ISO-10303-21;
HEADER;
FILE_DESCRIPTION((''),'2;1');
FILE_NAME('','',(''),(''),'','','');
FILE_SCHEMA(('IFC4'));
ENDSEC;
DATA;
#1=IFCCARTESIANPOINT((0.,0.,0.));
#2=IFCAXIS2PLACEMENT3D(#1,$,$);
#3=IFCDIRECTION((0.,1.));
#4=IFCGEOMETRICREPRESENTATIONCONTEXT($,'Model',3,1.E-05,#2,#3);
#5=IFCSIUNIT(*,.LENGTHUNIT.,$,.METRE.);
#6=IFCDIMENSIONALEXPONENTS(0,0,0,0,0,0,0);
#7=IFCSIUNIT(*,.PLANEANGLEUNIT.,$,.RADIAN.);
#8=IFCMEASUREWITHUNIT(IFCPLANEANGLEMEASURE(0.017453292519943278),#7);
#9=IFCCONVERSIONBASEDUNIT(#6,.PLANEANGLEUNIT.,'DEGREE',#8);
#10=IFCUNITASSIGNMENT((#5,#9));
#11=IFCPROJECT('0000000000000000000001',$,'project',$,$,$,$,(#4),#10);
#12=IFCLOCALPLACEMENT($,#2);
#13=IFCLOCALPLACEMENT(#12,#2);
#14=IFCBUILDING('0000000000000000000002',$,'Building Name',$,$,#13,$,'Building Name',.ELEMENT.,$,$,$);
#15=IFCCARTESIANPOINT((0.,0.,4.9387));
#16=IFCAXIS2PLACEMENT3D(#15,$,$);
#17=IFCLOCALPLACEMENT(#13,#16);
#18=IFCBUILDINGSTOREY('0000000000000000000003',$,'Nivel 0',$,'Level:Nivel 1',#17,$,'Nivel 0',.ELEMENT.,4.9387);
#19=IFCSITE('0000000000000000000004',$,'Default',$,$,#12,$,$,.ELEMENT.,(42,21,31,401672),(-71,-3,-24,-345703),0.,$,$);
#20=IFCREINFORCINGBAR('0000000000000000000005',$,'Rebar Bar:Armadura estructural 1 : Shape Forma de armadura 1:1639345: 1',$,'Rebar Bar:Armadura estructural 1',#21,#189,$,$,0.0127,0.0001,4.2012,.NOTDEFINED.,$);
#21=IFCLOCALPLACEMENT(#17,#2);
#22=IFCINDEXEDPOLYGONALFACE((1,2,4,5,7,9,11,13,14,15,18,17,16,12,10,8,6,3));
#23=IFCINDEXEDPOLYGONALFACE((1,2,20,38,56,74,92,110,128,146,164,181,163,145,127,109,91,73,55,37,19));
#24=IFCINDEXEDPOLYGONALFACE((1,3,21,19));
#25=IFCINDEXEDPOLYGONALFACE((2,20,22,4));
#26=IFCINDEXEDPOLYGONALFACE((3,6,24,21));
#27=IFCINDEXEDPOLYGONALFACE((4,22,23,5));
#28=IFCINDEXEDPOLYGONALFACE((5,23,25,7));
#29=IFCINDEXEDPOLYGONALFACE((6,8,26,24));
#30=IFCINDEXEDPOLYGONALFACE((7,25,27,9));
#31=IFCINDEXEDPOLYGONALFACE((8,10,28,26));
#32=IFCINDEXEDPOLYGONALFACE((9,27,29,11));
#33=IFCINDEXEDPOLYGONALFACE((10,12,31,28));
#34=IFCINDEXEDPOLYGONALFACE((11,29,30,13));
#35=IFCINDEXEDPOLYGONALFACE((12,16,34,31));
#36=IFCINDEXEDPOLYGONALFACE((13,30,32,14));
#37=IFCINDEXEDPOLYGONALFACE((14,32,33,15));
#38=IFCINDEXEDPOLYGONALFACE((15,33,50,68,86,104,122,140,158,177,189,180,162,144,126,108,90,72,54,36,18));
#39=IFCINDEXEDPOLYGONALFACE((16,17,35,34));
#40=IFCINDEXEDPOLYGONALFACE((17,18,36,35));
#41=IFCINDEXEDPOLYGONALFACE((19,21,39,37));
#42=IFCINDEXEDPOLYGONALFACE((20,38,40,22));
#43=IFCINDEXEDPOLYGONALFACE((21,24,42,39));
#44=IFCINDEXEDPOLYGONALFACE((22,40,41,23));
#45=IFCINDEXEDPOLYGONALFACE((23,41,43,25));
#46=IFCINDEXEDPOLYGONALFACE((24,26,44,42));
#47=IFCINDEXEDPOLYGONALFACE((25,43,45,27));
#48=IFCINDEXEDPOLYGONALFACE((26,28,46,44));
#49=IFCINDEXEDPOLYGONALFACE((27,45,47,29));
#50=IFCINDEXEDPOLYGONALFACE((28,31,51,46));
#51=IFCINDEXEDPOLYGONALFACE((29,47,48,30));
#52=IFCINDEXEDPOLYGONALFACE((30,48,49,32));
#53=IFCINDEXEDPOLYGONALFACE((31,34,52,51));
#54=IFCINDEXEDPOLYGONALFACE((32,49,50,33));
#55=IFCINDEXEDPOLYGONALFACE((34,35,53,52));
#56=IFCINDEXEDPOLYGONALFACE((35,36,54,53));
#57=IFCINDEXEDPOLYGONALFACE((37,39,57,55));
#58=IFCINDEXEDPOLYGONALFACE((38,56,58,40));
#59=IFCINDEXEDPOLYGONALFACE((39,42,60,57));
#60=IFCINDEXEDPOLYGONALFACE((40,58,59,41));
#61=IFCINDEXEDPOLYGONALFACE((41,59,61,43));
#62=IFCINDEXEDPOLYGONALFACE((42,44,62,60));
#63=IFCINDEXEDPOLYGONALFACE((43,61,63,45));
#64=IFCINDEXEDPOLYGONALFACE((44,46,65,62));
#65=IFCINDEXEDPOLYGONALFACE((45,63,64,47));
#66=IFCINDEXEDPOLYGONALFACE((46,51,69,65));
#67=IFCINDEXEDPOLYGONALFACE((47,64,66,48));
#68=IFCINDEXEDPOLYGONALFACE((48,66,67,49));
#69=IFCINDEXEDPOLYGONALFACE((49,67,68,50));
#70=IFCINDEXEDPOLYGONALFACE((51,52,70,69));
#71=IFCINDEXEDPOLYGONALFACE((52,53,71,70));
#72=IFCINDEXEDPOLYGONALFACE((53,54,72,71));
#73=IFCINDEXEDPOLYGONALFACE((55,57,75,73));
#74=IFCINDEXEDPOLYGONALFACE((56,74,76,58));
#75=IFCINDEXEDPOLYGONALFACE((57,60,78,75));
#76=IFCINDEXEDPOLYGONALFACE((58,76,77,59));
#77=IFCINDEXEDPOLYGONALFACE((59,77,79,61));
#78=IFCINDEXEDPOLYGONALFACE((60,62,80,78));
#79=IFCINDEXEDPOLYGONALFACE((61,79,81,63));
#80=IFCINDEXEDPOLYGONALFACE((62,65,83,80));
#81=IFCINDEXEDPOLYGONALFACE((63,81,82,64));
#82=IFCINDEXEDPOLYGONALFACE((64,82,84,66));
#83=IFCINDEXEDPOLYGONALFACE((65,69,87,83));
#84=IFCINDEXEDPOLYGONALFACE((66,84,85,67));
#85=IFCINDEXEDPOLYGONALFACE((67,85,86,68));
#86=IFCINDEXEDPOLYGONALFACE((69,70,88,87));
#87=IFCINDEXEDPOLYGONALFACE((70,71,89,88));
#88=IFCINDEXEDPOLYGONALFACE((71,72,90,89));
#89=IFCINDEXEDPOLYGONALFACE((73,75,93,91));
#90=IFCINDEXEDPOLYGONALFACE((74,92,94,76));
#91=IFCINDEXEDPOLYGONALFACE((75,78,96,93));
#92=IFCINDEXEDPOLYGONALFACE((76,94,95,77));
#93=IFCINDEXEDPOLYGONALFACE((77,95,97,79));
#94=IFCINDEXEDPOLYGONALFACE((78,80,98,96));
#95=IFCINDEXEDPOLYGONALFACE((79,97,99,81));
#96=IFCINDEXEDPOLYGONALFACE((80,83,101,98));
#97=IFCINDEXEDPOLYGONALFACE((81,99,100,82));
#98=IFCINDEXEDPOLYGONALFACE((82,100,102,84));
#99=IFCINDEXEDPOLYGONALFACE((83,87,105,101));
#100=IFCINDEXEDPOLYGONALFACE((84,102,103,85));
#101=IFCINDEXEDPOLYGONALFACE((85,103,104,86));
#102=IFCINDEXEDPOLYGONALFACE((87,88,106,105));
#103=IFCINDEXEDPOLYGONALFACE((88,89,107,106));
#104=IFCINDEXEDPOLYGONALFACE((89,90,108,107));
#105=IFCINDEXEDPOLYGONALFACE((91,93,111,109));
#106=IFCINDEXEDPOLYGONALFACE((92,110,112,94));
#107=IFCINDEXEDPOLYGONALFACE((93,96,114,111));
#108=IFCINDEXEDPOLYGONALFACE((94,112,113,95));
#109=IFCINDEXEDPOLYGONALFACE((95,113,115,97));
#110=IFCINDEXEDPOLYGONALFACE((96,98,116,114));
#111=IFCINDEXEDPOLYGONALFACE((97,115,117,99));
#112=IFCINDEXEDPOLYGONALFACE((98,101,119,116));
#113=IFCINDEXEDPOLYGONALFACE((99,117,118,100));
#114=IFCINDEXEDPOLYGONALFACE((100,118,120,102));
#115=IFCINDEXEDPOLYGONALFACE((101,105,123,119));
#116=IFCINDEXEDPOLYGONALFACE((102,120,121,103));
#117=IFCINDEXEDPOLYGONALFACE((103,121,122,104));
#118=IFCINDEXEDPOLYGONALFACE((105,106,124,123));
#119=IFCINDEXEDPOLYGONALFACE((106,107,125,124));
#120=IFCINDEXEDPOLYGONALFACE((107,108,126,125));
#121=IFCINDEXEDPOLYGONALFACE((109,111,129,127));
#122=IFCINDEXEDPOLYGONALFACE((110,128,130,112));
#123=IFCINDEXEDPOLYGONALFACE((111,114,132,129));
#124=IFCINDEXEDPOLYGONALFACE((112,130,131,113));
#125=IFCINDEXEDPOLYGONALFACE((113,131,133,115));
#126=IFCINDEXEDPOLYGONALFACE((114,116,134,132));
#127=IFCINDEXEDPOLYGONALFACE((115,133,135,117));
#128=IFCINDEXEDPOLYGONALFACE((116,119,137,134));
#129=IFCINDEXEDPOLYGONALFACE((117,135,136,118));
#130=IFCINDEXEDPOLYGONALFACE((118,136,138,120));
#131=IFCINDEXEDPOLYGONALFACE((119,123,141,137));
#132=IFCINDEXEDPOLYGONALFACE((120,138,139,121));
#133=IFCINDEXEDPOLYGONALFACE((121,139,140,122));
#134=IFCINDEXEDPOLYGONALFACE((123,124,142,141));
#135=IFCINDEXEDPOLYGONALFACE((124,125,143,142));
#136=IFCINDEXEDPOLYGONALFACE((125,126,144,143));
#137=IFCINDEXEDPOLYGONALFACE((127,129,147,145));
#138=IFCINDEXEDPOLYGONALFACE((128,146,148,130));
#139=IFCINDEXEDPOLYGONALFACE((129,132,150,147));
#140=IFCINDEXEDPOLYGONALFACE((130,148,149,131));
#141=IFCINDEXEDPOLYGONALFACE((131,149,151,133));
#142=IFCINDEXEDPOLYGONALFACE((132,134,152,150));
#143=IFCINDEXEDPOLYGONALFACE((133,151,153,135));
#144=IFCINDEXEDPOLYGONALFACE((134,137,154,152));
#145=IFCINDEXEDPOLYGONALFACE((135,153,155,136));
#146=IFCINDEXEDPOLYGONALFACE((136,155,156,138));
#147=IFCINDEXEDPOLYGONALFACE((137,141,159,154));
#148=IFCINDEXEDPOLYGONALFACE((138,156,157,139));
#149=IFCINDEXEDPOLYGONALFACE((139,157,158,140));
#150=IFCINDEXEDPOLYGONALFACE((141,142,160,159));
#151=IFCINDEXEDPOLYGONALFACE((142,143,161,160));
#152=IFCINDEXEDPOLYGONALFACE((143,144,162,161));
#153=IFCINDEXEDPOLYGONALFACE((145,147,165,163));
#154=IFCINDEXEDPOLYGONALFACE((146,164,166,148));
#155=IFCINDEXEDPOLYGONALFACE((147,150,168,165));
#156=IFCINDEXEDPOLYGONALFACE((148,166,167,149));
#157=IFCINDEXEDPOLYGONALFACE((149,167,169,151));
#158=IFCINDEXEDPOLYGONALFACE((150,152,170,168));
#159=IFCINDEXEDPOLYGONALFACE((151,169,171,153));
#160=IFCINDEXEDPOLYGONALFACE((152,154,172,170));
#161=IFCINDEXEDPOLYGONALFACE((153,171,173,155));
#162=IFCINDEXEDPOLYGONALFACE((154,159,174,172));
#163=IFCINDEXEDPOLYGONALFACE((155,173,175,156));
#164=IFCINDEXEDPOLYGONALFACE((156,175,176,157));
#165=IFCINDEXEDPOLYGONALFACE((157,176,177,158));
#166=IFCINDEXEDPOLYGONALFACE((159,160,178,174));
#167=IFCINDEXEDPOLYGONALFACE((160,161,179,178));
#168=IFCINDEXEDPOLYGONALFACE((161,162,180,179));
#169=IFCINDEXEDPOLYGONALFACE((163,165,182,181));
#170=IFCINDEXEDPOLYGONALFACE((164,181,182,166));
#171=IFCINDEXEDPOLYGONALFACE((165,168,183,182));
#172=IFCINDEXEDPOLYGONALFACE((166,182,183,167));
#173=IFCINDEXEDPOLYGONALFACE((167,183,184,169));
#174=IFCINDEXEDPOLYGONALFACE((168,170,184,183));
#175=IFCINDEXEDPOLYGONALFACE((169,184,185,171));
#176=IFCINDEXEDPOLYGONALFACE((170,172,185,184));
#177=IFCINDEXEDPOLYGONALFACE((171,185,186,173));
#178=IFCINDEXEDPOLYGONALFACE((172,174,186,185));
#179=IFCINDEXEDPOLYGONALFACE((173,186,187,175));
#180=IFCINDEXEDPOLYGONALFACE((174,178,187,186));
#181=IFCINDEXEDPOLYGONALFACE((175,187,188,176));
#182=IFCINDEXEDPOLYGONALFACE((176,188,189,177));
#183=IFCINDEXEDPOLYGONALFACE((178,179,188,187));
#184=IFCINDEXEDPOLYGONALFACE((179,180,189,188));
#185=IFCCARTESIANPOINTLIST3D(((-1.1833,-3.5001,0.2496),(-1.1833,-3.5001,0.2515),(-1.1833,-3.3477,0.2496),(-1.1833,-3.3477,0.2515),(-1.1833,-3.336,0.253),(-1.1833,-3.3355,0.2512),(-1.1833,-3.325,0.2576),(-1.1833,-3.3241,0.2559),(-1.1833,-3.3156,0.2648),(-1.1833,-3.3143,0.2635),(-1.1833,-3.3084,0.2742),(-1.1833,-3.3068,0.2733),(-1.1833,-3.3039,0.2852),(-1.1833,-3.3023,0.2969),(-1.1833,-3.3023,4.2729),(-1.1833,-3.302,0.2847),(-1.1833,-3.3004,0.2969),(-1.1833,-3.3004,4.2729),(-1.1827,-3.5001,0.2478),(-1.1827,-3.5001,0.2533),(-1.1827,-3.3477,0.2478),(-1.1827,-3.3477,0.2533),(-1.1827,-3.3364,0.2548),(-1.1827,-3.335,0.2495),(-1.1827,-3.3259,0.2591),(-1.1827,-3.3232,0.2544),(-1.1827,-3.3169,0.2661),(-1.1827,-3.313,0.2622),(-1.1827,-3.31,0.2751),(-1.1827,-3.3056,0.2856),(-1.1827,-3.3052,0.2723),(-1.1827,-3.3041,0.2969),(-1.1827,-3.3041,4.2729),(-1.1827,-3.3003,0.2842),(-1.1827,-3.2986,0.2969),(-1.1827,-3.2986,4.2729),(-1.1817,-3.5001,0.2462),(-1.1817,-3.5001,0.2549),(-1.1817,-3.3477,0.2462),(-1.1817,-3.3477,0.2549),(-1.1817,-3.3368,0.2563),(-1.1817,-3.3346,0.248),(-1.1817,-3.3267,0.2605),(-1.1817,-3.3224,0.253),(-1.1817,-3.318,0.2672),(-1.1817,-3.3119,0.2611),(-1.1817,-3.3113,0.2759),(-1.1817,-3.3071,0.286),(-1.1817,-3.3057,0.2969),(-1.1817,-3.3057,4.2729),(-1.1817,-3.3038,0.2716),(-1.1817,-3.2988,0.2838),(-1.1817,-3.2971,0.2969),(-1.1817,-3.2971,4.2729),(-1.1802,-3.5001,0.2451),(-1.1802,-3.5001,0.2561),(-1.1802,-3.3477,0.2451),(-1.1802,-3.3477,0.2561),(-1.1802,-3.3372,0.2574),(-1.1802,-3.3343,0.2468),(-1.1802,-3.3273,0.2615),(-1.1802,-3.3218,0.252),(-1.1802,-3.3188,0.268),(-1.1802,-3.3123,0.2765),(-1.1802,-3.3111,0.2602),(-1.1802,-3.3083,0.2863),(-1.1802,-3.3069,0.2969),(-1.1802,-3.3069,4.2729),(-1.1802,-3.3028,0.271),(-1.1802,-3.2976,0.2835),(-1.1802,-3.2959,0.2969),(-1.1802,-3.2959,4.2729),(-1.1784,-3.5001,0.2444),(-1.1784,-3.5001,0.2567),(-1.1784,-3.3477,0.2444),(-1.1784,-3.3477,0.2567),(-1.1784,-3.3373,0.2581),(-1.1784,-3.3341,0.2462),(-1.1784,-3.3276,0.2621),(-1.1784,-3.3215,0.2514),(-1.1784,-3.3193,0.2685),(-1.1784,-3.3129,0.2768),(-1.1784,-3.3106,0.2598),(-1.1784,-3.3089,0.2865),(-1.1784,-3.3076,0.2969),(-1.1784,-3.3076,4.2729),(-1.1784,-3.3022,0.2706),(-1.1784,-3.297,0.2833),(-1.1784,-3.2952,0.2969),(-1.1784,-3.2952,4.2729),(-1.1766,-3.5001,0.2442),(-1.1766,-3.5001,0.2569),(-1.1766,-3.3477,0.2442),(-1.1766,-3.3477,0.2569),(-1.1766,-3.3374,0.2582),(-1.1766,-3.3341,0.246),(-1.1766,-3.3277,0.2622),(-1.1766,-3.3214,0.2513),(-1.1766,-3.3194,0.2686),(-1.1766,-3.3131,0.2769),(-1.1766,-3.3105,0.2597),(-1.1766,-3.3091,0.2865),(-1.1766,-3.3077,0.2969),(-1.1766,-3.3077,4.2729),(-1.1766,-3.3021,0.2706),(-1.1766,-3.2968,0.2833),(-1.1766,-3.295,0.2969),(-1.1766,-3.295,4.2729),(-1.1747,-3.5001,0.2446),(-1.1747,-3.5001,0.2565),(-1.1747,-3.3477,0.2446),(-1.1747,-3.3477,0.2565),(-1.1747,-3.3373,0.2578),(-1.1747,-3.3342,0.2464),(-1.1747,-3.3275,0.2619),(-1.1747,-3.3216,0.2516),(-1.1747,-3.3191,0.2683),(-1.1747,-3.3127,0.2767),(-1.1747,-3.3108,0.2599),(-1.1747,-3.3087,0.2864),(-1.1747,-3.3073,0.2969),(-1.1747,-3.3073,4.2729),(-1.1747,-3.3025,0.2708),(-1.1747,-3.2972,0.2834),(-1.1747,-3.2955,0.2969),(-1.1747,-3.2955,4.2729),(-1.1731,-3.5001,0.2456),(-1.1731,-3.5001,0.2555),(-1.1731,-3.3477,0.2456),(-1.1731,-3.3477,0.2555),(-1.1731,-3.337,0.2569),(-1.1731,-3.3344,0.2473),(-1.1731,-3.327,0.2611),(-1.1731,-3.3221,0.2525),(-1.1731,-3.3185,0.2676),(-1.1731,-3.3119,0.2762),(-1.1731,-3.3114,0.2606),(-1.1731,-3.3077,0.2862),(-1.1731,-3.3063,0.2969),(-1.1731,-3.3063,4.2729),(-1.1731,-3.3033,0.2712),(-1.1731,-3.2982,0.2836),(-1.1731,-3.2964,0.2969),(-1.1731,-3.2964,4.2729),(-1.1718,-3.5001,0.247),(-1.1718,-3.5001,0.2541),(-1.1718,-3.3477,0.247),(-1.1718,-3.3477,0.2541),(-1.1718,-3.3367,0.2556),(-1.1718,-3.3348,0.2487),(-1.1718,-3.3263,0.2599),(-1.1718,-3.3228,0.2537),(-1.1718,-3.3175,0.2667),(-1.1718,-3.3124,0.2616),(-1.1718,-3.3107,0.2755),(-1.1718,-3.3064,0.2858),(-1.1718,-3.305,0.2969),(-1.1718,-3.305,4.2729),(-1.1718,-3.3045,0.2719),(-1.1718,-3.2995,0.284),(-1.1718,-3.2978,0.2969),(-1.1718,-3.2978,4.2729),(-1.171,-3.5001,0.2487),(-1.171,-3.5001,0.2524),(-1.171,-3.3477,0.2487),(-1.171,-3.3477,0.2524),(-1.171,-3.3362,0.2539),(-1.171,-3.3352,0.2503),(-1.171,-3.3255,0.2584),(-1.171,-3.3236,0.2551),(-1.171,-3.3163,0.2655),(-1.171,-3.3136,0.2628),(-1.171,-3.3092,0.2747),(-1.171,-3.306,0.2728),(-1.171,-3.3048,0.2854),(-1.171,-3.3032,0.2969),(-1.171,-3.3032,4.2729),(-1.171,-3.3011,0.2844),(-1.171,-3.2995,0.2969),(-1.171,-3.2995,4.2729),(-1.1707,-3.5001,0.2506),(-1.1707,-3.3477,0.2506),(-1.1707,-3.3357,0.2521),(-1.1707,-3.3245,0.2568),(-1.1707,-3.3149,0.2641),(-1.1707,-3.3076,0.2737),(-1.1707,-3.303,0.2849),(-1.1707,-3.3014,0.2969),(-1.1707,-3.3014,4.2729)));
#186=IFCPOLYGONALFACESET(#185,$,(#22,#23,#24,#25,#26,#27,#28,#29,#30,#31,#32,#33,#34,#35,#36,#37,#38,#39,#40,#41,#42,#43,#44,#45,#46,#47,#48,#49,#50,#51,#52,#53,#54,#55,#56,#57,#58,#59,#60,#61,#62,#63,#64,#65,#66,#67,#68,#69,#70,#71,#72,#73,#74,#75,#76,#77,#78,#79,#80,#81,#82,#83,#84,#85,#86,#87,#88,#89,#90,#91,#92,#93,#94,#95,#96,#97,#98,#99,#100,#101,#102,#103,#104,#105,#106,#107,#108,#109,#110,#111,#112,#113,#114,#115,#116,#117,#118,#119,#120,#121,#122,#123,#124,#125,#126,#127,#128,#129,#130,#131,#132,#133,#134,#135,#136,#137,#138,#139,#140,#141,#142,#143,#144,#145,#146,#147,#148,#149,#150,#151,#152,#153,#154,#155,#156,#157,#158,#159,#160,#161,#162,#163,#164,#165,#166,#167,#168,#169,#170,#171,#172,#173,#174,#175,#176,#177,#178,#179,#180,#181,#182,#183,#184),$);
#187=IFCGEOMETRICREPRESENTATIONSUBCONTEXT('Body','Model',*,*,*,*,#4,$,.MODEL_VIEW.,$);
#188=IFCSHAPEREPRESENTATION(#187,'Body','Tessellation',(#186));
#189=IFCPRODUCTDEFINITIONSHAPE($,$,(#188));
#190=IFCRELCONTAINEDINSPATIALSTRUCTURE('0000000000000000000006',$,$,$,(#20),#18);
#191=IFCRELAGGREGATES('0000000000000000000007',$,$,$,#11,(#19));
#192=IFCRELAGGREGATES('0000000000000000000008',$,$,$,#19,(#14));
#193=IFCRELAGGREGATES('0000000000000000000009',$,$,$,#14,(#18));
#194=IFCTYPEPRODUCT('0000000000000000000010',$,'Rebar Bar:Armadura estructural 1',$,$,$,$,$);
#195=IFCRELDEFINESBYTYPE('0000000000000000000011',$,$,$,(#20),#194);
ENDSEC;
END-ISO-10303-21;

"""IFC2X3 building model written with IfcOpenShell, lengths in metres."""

from ifc_helpers import new_model, entity, si_unit, converted_unit, direction, frame, origin, place, context, subcontext, project, spatial, type_object, element, save


model = new_model("IFC2X3")

# Units and contexts
model_context = context("Model", 3, precision=1e-05, world=origin(), true_north=direction((0.0, 1.0)))
body_context = subcontext(model_context, "Body", "Model", "MODEL_VIEW")
ifc_project = project(units=[si_unit("LENGTHUNIT", "METRE"), converted_unit("PLANEANGLEUNIT", "DEGREE", entity("IfcPlaneAngleMeasure", 0.017453292519943278), si_unit("PLANEANGLEUNIT", "RADIAN"), dimensions=[0, 0, 0, 0, 0, 0, 0])], contexts=[model_context])

# Site, building, storey
site_placement = place(None, origin())
site = spatial("IfcSite", under=ifc_project, at=site_placement, Name="Default", CompositionType="ELEMENT", RefLatitude=(42, 21, 31, 401672), RefLongitude=(-71, -3, -24, -345703), RefElevation=0.0)
building_placement = place(site_placement, origin())
building = spatial("IfcBuilding", under=site, at=building_placement, Name="Building Name", LongName="Building Name", CompositionType="ELEMENT")
storey_placement = place(building_placement, frame((0.0, 0.0, 4.9387)))
storey = spatial("IfcBuildingStorey", under=building, at=storey_placement, Name="Nivel 0", ObjectType="Level:Nivel 1", LongName="Nivel 0", CompositionType="ELEMENT", Elevation=4.9387)

# Reinforcing bar
type_product = type_object("IfcTypeProduct", Name="Rebar Bar:Armadura estructural 1")
reinforcing_bar_1_placement = place(storey_placement, origin())
element("IfcReinforcingBar", 1, at=reinforcing_bar_1_placement, inside=storey, type_object=type_product, Name="Rebar Bar:Armadura estructural 1 : Shape Forma de armadura 1:1639345: 1", ObjectType="Rebar Bar:Armadura estructural 1", BarLength=4.2012, BarRole="NOTDEFINED", CrossSectionArea=0.0001, NominalDiameter=0.0127, context=body_context, shape_type="AdvancedSweptSolid", body=[
    entity("IfcSweptDiskSolid", entity("IfcCompositeCurve", [entity("IfcCompositeCurveSegment", "CONTINUOUS", True, entity("IfcPolyline", [entity("IfcCartesianPoint", [-1.177, -3.5001, 0.2506]), entity("IfcCartesianPoint", [-1.177, -3.3477, 0.2506])])), entity("IfcCompositeCurveSegment", "CONTINUOUS", True, entity("IfcTrimmedCurve", entity("IfcCircle", entity("IfcAxis2Placement3D", entity("IfcCartesianPoint", [-1.177, -3.3477, 0.2969]), entity("IfcDirection", [1.0, 0.0, 0.0]), entity("IfcDirection", [0.0, 1.0, 0.0])), 0.0464), [entity("IfcParameterValue", 270.0)], [entity("IfcParameterValue", 360.0)], True, "PARAMETER")), entity("IfcCompositeCurveSegment", "CONTINUOUS", True, entity("IfcPolyline", [entity("IfcCartesianPoint", [-1.177, -3.3014, 0.2969]), entity("IfcCartesianPoint", [-1.177, -3.3014, 4.2729])]))], False), 0.0063, None, 0.0, 92.0),
])

save(model, "model.ifc")
